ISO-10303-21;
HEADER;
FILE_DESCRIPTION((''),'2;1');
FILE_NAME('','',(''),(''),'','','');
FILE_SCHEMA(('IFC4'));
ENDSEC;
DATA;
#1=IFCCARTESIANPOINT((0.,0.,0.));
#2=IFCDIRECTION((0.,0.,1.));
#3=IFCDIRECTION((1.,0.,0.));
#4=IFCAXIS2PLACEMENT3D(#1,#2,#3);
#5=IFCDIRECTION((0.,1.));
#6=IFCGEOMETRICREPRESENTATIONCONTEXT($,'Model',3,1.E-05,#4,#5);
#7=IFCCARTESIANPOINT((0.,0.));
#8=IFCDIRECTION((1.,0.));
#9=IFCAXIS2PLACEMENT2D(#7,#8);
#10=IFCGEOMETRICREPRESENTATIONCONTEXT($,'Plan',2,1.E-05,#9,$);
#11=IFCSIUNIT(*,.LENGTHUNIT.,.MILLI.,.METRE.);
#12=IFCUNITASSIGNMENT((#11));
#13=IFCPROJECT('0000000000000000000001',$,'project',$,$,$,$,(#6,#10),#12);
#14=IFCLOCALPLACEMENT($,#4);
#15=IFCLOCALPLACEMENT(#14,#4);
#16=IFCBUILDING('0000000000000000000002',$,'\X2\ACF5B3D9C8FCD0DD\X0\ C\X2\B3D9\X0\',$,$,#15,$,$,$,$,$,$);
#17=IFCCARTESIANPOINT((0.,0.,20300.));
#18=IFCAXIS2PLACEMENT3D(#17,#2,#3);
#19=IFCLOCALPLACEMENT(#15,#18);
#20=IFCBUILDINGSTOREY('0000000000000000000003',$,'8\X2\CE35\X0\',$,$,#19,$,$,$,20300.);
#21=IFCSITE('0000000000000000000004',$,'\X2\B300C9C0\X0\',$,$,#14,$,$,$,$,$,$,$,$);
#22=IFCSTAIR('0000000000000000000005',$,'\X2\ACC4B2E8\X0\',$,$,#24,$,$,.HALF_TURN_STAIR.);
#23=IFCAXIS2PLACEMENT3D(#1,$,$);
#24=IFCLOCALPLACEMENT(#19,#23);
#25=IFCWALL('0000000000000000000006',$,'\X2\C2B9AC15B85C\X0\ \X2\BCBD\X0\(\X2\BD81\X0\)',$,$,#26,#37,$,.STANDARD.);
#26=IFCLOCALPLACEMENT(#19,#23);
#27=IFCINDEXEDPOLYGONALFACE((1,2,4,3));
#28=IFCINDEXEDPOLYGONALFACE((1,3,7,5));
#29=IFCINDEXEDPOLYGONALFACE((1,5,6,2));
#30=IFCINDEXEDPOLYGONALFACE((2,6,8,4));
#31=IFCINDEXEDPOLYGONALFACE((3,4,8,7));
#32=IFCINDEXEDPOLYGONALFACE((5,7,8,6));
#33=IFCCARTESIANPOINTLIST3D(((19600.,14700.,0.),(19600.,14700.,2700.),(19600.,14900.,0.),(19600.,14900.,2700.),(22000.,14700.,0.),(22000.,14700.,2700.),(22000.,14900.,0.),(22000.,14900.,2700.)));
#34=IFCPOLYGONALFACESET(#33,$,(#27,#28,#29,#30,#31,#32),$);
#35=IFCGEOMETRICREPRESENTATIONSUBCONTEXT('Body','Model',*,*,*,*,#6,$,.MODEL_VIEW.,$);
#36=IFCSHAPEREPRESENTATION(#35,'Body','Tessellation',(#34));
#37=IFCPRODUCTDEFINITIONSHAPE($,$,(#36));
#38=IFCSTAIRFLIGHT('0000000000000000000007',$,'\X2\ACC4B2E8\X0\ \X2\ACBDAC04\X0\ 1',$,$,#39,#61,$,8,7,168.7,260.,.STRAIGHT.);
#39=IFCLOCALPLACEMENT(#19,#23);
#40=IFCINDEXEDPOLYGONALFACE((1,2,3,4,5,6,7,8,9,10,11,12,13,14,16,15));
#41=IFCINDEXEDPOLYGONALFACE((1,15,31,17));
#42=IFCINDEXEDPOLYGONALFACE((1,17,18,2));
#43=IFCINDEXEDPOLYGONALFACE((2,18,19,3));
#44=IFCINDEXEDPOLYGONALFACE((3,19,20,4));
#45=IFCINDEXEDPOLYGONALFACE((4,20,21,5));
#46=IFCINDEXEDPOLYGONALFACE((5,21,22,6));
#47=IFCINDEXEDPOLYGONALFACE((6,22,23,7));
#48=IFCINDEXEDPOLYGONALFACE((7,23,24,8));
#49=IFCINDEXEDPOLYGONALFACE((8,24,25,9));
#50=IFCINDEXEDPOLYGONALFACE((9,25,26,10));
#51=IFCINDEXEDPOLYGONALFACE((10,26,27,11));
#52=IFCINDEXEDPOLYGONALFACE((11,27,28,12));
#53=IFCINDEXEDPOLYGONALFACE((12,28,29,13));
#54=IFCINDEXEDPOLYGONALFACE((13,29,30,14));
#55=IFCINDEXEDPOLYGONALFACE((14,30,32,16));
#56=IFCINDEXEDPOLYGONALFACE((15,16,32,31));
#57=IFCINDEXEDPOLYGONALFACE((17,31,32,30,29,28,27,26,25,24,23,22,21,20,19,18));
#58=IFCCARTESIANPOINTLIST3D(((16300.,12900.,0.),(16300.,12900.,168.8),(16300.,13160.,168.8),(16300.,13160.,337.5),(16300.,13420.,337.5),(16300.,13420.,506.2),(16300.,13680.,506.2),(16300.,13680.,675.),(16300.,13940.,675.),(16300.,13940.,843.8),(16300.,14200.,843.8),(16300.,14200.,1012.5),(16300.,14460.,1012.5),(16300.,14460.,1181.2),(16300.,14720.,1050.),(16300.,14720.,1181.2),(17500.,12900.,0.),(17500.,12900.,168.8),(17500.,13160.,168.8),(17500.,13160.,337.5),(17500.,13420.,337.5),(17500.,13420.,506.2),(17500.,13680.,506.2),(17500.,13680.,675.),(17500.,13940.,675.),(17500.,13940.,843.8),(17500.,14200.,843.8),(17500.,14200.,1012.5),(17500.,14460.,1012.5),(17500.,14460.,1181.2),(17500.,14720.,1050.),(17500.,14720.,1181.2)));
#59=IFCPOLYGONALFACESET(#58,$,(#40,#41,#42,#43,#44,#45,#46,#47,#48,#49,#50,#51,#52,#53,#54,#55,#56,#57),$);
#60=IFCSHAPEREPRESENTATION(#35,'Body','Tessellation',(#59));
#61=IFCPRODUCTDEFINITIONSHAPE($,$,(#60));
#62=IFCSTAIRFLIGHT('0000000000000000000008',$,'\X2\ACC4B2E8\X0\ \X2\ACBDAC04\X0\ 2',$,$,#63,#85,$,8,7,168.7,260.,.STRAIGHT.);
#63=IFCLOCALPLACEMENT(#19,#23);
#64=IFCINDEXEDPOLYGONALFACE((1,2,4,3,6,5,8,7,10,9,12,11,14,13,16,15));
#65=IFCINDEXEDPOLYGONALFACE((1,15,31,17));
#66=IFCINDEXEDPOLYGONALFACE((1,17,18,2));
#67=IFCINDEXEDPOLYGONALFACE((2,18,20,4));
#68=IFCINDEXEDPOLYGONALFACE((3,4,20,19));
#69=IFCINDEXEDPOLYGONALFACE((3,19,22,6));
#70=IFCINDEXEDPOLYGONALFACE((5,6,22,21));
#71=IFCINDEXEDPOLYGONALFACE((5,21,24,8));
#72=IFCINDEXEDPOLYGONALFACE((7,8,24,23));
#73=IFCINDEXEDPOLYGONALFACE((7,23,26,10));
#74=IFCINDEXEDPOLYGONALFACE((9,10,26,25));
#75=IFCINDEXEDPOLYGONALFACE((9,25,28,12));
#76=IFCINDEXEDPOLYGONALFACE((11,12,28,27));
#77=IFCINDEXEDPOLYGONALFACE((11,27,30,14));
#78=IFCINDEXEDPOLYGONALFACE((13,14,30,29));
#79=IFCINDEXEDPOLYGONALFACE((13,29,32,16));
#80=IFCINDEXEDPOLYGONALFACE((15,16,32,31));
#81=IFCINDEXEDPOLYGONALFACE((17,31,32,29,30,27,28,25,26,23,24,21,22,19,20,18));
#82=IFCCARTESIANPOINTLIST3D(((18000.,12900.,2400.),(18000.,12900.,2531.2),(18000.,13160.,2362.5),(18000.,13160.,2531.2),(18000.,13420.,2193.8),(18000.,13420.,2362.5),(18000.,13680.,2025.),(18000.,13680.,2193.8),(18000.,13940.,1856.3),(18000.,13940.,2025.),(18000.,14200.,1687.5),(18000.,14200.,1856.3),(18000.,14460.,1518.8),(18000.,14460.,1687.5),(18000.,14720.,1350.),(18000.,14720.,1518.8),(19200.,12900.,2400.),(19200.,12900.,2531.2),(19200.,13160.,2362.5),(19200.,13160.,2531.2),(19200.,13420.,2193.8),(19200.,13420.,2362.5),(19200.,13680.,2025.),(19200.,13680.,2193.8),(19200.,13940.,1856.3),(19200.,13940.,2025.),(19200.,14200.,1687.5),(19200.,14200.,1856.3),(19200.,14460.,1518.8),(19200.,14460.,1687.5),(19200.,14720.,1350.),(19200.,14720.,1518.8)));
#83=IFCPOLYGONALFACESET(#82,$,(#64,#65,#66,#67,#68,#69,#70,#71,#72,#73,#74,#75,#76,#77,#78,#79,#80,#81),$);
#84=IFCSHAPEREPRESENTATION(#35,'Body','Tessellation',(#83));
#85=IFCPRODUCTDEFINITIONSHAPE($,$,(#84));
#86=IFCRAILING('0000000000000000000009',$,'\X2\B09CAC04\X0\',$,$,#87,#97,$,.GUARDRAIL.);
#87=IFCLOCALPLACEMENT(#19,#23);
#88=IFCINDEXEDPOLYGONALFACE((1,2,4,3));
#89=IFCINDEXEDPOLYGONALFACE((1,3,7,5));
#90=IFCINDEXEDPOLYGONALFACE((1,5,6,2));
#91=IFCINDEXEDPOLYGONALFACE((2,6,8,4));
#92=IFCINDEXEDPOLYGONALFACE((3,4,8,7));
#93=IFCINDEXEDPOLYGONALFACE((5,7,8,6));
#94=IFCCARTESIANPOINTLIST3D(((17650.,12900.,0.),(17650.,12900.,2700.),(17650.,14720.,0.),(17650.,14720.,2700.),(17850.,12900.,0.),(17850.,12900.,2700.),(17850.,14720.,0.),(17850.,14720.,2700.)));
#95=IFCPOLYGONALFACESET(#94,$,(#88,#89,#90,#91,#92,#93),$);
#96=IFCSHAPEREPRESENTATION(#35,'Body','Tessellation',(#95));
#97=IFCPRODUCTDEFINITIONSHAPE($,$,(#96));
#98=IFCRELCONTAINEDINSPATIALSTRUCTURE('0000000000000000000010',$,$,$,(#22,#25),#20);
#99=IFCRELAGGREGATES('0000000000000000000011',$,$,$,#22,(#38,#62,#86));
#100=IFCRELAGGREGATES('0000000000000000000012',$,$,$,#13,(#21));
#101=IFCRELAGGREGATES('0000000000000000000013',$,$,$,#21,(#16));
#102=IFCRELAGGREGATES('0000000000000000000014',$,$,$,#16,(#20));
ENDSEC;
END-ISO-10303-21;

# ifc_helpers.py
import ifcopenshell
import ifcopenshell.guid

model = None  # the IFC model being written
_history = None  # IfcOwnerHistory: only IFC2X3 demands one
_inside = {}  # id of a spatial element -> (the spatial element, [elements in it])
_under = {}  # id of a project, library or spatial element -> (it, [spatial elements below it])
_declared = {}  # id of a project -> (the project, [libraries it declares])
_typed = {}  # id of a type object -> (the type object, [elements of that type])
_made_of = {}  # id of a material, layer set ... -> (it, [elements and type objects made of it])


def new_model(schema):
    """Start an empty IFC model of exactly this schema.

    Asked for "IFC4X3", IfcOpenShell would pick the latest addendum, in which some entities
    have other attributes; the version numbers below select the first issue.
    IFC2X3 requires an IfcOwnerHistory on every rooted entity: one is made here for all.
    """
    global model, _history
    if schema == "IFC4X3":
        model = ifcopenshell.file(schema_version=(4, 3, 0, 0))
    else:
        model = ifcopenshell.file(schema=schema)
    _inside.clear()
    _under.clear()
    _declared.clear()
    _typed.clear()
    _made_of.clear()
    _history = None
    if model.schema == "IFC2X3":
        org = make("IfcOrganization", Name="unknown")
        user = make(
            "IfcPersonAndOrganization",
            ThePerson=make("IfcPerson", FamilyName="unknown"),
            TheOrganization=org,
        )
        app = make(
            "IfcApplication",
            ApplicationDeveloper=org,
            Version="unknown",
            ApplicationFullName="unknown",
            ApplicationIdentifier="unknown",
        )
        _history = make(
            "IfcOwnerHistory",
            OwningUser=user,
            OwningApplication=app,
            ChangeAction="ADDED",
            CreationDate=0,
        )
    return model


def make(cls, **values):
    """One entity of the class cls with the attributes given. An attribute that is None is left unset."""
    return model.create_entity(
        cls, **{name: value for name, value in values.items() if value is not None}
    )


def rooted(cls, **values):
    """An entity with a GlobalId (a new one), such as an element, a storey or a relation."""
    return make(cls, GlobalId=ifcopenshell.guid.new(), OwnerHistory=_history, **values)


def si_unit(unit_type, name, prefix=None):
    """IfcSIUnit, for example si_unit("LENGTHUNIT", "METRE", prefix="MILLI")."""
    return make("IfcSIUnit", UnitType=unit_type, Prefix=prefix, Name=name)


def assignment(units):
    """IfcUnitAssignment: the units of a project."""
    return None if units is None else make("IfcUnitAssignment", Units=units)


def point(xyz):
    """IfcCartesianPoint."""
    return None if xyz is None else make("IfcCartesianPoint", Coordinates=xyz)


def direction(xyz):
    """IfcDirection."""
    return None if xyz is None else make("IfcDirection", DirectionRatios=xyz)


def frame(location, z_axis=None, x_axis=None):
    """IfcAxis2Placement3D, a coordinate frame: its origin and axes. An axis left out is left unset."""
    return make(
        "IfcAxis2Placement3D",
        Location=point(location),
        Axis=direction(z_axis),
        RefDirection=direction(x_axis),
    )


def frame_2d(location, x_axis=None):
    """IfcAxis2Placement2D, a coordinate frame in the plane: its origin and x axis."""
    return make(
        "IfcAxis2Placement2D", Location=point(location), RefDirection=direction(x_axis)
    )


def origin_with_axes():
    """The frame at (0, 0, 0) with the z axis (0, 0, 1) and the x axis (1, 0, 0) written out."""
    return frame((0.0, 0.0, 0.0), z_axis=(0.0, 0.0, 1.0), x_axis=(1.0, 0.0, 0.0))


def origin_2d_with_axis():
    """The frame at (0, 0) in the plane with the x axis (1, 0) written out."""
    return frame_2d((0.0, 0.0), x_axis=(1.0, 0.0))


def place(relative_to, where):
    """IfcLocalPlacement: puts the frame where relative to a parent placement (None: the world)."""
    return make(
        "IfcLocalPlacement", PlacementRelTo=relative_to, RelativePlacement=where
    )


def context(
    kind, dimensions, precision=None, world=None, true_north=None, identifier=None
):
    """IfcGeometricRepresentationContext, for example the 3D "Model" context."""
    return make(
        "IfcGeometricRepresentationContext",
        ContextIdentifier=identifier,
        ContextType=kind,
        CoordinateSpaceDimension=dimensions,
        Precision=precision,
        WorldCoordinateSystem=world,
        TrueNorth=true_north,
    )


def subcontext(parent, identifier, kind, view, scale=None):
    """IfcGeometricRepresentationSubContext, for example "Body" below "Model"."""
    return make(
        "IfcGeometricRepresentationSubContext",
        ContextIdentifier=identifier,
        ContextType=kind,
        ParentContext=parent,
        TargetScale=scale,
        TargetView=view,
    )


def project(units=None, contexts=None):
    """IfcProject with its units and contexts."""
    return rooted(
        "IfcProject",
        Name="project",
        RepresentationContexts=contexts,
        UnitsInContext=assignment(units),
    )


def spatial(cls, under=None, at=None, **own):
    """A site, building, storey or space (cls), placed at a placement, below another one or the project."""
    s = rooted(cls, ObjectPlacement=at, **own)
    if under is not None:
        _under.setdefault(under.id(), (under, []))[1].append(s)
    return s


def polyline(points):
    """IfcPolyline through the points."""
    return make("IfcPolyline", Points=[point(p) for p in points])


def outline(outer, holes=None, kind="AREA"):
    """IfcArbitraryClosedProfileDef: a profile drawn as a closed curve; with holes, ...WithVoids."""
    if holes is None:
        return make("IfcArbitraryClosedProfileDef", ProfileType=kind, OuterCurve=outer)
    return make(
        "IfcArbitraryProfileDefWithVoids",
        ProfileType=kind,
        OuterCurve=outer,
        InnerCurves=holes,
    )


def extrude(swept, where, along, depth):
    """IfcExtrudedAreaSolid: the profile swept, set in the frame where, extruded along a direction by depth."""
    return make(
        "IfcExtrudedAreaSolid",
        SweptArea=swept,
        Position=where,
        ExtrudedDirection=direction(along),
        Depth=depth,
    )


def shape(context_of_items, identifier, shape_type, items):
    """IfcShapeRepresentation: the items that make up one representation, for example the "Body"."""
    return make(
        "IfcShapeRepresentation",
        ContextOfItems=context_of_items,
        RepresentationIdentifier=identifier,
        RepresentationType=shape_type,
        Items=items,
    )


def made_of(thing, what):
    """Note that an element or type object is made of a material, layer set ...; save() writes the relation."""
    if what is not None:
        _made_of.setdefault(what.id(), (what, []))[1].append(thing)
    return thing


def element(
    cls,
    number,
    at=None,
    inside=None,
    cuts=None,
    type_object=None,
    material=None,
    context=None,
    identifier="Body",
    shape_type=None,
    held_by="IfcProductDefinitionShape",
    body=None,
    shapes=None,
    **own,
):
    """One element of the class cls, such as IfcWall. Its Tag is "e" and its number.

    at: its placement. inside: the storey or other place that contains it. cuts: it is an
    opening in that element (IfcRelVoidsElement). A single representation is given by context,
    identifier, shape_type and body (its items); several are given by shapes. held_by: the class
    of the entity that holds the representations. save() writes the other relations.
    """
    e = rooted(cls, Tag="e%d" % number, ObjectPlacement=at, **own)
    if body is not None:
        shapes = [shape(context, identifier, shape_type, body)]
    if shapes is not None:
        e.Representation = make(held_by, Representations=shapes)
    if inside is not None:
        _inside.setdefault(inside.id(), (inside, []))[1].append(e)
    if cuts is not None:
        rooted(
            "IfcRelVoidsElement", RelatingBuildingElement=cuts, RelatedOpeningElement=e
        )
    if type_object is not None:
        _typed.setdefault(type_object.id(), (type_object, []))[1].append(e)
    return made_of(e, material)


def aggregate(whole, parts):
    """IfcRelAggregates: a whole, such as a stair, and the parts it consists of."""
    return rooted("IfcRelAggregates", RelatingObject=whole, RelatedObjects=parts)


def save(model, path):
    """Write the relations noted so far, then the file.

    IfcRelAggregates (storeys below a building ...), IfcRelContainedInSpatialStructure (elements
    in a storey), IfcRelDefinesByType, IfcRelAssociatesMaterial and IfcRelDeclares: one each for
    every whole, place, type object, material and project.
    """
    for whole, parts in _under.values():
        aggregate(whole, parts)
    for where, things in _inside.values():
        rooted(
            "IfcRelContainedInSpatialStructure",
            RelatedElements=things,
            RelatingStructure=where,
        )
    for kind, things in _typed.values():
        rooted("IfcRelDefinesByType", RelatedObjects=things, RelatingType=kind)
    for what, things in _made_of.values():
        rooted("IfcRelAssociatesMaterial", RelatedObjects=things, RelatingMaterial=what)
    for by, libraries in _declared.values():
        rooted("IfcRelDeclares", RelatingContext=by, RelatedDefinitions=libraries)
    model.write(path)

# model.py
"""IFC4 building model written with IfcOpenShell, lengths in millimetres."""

from ifc_helpers import new_model, si_unit, direction, frame, origin_with_axes, origin_2d_with_axis, place, context, subcontext, project, spatial, polyline, outline, extrude, element, aggregate, save


model = new_model("IFC4")

# Units and contexts
model_context = context("Model", 3, precision=1e-05, world=origin_with_axes(), true_north=direction((0.0, 1.0)))
plan_context = context("Plan", 2, precision=1e-05, world=origin_2d_with_axis())
body_context = subcontext(model_context, "Body", "Model", "MODEL_VIEW")
ifc_project = project(units=[si_unit("LENGTHUNIT", "METRE", prefix="MILLI")], contexts=[model_context, plan_context])

# Site, building, storey
site_placement = place(None, origin_with_axes())
site = spatial("IfcSite", under=ifc_project, at=site_placement, Name="대지")
building_placement = place(site_placement, origin_with_axes())
building = spatial("IfcBuilding", under=site, at=building_placement, Name="공동주택 C동")
storey_placement = place(building_placement, frame((0.0, 0.0, 20300.0), z_axis=(0.0, 0.0, 1.0), x_axis=(1.0, 0.0, 0.0)))
storey = spatial("IfcBuildingStorey", under=building, at=storey_placement, Name="8층", Elevation=20300.0)

# Stair
stair_placement = place(storey_placement, origin_with_axes())
stair = element("IfcStair", 1, at=stair_placement, inside=storey, Name="계단", PredefinedType="HALF_TURN_STAIR")

# Wall
wall_1_placement = place(storey_placement, origin_with_axes())
element("IfcWall", 2, at=wall_1_placement, inside=storey, Name="승강로 벽(북)", PredefinedType="STANDARD", context=body_context, shape_type="SweptSolid", body=[
    extrude(outline(polyline([(19600.0, 14900.0), (22000.0, 14900.0), (22000.0, 14700.0), (19600.0, 14700.0), (19600.0, 14900.0)])), origin_with_axes(), (0.0, 0.0, 1.0), 2700.0),
])

# Stair flights
stair_flight_1_placement = place(stair_placement, origin_with_axes())
stair_flight_1 = element("IfcStairFlight", 3, at=stair_flight_1_placement, Name="계단 경간 1", NumberOfRisers=8, NumberOfTreads=7, PredefinedType="STRAIGHT", RiserHeight=168.7, TreadLength=260.0, context=body_context, shape_type="SweptSolid", body=[
    extrude(outline(polyline([(0.0, 0.0), (0.0, 168.7), (260.0, 168.7), (260.0, 337.5), (520.0, 337.5), (520.0, 506.2), (780.0, 506.2), (780.0, 675.0), (1040.0, 675.0), (1040.0, 843.7), (1300.0, 843.7), (1300.0, 1012.5), (1560.0, 1012.5), (1560.0, 1181.2), (1820.0, 1181.2), (1820.0, 1350.0), (1820.0, 1050.0), (0.0, 0.0)])), frame((16300.0, 12900.0, 0.0), z_axis=(1.0, 0.0, 0.0), x_axis=(0.0, 1.0, 0.0)), (0.0, 0.0, 1.0), 1200.0),
])
stair_flight_2_placement = place(stair_placement, origin_with_axes())
stair_flight_2 = element("IfcStairFlight", 4, at=stair_flight_2_placement, Name="계단 경간 2", NumberOfRisers=8, NumberOfTreads=7, PredefinedType="STRAIGHT", RiserHeight=168.7, TreadLength=260.0, context=body_context, shape_type="SweptSolid", body=[
    extrude(outline(polyline([(0.0, 0.0), (0.0, 168.7), (260.0, 168.7), (260.0, 337.5), (520.0, 337.5), (520.0, 506.2), (780.0, 506.2), (780.0, 675.0), (1040.0, 675.0), (1040.0, 843.7), (1300.0, 843.7), (1300.0, 1012.5), (1560.0, 1012.5), (1560.0, 1181.2), (1820.0, 1181.2), (1820.0, 1350.0), (1820.0, 1050.0), (0.0, 0.0)])), frame((19200.0, 14720.0, 1350.0), z_axis=(-1.0, 0.0, 0.0), x_axis=(0.0, -1.0, 0.0)), (0.0, 0.0, 1.0), 1200.0),
])

# Railing
railing_placement = place(stair_placement, origin_with_axes())
railing = element("IfcRailing", 5, at=railing_placement, Name="난간", PredefinedType="GUARDRAIL", context=body_context, shape_type="SweptSolid", body=[
    extrude(outline(polyline([(17650.0, 12900.0), (17850.0, 12900.0), (17850.0, 14720.0), (17650.0, 14720.0), (17650.0, 12900.0)])), origin_with_axes(), (0.0, 0.0, 1.0), 2700.0),
])
aggregate(stair, [stair_flight_1, stair_flight_2, railing])

save(model, "model.ifc")
